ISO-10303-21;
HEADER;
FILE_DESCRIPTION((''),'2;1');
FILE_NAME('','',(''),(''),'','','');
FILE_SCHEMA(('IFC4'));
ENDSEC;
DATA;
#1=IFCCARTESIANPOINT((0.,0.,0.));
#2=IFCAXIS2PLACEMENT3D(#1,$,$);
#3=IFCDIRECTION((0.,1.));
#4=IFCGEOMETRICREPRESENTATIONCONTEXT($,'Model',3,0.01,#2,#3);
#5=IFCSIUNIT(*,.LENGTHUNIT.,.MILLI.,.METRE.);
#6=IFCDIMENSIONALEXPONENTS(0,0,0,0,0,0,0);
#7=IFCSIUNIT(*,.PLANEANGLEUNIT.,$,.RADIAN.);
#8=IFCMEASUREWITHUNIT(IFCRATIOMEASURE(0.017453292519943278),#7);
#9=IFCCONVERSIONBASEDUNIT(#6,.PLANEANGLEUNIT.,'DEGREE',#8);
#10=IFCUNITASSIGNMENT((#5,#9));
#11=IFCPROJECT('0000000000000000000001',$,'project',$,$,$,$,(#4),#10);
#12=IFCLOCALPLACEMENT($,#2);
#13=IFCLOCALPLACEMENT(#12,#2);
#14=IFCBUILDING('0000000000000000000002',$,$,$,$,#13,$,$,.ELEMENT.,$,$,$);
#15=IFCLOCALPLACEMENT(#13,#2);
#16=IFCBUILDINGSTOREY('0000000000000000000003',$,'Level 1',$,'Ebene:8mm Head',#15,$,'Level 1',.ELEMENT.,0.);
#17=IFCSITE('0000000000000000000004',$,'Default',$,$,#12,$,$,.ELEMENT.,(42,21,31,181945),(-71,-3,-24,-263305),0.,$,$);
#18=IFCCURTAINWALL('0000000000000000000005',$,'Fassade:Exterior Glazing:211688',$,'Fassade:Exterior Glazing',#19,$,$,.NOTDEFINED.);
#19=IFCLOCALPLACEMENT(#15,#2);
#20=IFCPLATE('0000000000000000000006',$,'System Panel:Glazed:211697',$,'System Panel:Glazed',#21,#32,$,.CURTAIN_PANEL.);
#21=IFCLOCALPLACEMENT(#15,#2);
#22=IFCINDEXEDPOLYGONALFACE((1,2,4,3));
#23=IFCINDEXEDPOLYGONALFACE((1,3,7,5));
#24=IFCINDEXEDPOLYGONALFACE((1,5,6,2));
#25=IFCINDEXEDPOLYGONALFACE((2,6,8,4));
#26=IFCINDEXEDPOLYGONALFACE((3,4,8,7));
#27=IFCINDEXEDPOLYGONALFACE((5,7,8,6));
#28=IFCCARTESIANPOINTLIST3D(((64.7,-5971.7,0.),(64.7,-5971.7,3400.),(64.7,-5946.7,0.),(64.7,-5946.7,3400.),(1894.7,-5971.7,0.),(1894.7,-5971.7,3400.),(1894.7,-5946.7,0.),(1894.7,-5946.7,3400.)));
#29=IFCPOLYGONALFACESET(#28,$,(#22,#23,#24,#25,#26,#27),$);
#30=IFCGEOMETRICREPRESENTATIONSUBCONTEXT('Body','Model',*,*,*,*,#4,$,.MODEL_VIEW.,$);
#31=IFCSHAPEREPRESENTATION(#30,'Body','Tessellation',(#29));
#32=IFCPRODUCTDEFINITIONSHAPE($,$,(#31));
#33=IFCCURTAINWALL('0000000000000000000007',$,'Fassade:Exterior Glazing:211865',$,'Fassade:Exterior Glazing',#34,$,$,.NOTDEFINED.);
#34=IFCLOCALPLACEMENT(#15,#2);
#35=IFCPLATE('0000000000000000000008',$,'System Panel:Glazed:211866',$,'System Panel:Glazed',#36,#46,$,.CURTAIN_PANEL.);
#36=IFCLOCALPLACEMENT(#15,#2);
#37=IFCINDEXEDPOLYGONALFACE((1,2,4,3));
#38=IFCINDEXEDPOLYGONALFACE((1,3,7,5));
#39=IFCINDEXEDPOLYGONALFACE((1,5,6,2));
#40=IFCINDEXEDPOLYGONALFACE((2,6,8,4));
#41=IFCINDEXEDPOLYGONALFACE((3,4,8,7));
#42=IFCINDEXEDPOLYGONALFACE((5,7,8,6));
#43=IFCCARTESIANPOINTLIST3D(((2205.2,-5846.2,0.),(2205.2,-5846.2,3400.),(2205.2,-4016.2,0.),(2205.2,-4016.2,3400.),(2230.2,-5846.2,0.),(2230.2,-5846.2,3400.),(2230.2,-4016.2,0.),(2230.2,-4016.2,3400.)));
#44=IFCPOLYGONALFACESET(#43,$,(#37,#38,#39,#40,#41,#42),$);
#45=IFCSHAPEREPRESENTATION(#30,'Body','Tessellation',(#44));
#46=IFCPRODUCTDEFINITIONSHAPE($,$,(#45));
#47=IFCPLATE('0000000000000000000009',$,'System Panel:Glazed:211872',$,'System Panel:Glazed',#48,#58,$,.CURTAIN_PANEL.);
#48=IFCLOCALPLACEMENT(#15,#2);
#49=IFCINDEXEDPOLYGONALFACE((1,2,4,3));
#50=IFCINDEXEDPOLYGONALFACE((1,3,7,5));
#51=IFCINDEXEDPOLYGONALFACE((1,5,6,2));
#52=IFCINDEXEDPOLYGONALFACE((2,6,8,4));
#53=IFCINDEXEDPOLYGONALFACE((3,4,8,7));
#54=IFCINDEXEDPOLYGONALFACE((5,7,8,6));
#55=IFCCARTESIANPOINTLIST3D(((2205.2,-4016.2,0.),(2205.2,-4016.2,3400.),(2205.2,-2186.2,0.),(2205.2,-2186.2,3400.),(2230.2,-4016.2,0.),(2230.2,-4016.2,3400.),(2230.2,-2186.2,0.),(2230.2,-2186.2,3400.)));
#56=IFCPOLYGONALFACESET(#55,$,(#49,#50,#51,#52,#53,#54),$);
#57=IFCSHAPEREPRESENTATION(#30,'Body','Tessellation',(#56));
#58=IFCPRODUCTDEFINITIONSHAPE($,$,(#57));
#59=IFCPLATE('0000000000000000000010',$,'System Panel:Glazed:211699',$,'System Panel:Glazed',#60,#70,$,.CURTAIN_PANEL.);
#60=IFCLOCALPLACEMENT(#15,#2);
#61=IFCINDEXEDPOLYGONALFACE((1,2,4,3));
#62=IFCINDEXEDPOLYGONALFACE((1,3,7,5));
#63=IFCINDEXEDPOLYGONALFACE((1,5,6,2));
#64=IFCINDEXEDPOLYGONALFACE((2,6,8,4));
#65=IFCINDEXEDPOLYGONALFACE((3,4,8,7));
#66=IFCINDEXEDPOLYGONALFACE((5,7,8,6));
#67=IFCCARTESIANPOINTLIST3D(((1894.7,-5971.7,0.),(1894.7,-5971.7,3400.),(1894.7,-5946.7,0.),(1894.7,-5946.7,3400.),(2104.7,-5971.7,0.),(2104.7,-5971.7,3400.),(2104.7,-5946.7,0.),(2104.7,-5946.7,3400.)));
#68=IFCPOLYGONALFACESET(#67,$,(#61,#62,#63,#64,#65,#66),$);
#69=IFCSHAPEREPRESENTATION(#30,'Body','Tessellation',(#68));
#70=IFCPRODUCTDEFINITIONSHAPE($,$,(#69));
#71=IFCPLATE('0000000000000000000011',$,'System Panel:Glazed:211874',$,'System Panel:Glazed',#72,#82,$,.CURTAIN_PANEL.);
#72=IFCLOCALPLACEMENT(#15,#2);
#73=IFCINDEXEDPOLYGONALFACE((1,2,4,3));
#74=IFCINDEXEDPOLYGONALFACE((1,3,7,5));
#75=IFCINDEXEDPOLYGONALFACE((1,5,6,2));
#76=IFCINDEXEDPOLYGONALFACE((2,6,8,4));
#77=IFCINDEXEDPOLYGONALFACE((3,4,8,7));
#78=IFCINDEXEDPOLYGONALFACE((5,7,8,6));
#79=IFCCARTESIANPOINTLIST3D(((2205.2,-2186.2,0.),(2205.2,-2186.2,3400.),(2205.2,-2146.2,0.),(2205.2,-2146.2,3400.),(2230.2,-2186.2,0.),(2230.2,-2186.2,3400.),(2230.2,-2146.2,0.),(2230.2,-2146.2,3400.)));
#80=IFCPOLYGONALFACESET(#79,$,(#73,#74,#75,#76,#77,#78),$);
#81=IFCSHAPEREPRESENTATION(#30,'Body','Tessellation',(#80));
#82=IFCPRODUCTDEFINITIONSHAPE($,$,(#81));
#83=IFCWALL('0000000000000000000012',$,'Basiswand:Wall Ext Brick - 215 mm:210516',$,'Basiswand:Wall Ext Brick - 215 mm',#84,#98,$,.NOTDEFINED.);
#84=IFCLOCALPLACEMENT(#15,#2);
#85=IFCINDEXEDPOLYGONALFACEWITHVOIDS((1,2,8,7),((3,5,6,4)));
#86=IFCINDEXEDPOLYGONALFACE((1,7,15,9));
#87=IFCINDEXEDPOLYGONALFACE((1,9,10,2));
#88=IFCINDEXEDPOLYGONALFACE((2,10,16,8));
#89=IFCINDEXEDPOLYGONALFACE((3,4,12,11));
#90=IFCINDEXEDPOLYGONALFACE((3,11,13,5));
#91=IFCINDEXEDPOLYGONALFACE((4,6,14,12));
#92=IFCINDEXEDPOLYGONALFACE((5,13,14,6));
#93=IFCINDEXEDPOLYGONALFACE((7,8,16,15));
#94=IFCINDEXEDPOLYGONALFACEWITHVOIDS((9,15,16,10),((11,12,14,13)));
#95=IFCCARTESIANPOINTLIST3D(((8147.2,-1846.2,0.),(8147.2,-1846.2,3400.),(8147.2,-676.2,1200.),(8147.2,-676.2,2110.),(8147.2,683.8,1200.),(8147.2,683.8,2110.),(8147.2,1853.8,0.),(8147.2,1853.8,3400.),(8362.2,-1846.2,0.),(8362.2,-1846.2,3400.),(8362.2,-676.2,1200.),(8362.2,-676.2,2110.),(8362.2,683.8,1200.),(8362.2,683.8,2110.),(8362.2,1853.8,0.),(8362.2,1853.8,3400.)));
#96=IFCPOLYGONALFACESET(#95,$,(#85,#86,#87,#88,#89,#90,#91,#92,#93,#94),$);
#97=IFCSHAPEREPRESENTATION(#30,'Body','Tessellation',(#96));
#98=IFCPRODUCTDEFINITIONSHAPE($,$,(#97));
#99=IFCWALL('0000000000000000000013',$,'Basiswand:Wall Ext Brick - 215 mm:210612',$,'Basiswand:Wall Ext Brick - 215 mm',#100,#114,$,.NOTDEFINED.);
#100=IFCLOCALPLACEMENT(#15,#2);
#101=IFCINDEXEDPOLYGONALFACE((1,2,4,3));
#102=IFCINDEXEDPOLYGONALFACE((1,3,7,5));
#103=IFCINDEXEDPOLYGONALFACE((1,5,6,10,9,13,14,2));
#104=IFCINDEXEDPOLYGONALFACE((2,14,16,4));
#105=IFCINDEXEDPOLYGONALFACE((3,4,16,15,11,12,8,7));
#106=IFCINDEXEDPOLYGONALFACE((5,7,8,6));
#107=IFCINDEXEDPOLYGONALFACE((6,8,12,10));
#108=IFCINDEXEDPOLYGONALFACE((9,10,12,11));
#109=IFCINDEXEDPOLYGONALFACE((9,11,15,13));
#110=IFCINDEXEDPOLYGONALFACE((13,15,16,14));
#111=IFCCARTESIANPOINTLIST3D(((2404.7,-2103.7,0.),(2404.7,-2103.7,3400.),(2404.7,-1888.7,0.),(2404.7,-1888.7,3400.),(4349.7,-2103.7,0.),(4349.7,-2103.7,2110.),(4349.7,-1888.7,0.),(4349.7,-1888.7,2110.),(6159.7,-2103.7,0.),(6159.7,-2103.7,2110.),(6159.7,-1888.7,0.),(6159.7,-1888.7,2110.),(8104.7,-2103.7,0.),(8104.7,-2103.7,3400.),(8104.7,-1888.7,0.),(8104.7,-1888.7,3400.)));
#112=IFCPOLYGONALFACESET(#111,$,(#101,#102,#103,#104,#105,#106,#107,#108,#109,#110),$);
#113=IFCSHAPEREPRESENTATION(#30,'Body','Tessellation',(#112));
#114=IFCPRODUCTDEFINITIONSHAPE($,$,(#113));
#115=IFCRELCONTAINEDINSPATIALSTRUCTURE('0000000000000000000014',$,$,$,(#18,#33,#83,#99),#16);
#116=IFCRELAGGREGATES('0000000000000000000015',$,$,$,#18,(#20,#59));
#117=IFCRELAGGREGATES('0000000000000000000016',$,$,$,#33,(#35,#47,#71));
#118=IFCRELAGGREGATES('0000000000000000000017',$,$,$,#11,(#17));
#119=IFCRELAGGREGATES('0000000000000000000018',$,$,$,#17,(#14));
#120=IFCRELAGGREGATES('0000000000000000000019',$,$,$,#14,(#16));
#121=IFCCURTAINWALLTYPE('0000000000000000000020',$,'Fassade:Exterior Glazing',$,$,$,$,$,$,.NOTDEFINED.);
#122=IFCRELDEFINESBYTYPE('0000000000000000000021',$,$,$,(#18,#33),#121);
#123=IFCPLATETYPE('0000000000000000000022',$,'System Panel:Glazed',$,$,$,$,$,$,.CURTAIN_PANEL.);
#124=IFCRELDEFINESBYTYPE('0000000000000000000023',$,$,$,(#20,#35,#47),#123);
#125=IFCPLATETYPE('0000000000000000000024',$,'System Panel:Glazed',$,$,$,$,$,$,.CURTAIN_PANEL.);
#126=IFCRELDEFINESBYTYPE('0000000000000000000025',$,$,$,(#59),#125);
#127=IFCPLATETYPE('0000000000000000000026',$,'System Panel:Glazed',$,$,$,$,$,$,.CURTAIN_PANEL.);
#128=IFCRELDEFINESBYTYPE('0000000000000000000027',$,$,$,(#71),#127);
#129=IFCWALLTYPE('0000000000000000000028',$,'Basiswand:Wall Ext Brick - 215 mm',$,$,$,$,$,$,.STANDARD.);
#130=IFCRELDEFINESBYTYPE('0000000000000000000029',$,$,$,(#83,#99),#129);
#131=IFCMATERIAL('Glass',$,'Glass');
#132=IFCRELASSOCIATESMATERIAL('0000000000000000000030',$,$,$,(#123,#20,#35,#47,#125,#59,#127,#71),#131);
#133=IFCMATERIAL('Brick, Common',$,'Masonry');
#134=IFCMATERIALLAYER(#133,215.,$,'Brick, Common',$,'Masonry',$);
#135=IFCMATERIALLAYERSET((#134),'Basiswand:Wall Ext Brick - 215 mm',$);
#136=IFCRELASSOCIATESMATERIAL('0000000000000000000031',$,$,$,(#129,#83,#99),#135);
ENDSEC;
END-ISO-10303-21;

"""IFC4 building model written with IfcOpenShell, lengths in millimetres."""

from ifc_helpers import new_model, entity, si_unit, converted_unit, direction, frame, frame_2d, origin, origin_2d_with_axis, place, context, subcontext, project, spatial, rectangle, extrude, source, transform, mapped, material, layer, layer_set, layer_usage, type_object, type_shapes, element, aggregate, save


model = new_model("IFC4")

# Units and contexts
model_context = context("Model", 3, precision=0.01, world=origin(), true_north=direction((0.0, 1.0)))
body_context = subcontext(model_context, "Body", "Model", "MODEL_VIEW")
ifc_project = project(units=[si_unit("LENGTHUNIT", "METRE", prefix="MILLI"), converted_unit("PLANEANGLEUNIT", "DEGREE", entity("IfcRatioMeasure", 0.017453292519943278), si_unit("PLANEANGLEUNIT", "RADIAN"), dimensions=[0, 0, 0, 0, 0, 0, 0])], contexts=[model_context])

# Site, building, storey
site_placement = place(None, origin())
site = spatial("IfcSite", under=ifc_project, at=site_placement, Name="Default", CompositionType="ELEMENT", RefLatitude=(42, 21, 31, 181945), RefLongitude=(-71, -3, -24, -263305), RefElevation=0.0)
building_placement = place(site_placement, origin())
building = spatial("IfcBuilding", under=site, at=building_placement, CompositionType="ELEMENT")
storey_placement = place(building_placement, origin())
storey = spatial("IfcBuildingStorey", under=building, at=storey_placement, Name="Level 1", ObjectType="Ebene:8mm Head", LongName="Level 1", CompositionType="ELEMENT", Elevation=0.0)

# Curtain wall, plate
curtain_wall_type = type_object("IfcCurtainWallType", Name="Fassade:Exterior Glazing", PredefinedType="NOTDEFINED")
curtain_wall_1_placement = place(storey_placement, origin())
curtain_wall_1 = element("IfcCurtainWall", 1, at=curtain_wall_1_placement, inside=storey, type_object=curtain_wall_type, Name="Fassade:Exterior Glazing:211688", ObjectType="Fassade:Exterior Glazing", PredefinedType="NOTDEFINED")
ifc_material_1 = material(Name="Glass", Category="Glass")
plate_type_1 = type_object("IfcPlateType", Name="System Panel:Glazed", PredefinedType="CURTAIN_PANEL", material=ifc_material_1)
shared_shape_1 = source(origin(), body_context, "Body", "SweptSolid", [
    extrude(rectangle(XDim=25.0, YDim=1830.0, at=origin_2d_with_axis()), frame((915.0, 12.5, 0.0), z_axis=(0.0, 0.0, 1.0), x_axis=(0.0, 1.0, 0.0)), (0.0, 0.0, 1.0), 3400.0),
])
type_shapes(plate_type_1, [shared_shape_1])
plate_1_placement = place(curtain_wall_1_placement, frame((64.7, -5971.7, 0.0)))
plate_1 = element("IfcPlate", 2, at=plate_1_placement, type_object=plate_type_1, material=ifc_material_1, Name="System Panel:Glazed:211697", ObjectType="System Panel:Glazed", PredefinedType="CURTAIN_PANEL", context=body_context, shape_type="MappedRepresentation", body=[
    mapped(shared_shape_1, transform((0.0, 0.0, 0.0), scale=1.0)),
])

# Curtain wall, plates
curtain_wall_2_placement = place(storey_placement, origin())
curtain_wall_2 = element("IfcCurtainWall", 3, at=curtain_wall_2_placement, inside=storey, type_object=curtain_wall_type, Name="Fassade:Exterior Glazing:211865", ObjectType="Fassade:Exterior Glazing", PredefinedType="NOTDEFINED")
plate_2_placement = place(curtain_wall_2_placement, frame((2230.2, -5846.2, 0.0), z_axis=(0.0, 0.0, 1.0), x_axis=(0.0, 1.0, 0.0)))
plate_2 = element("IfcPlate", 4, at=plate_2_placement, type_object=plate_type_1, material=ifc_material_1, Name="System Panel:Glazed:211866", ObjectType="System Panel:Glazed", PredefinedType="CURTAIN_PANEL", context=body_context, shape_type="MappedRepresentation", body=[
    mapped(shared_shape_1, transform((0.0, 0.0, 0.0), scale=1.0)),
])
plate_3_placement = place(curtain_wall_2_placement, frame((2230.2, -4016.2, 0.0), z_axis=(0.0, 0.0, 1.0), x_axis=(0.0, 1.0, 0.0)))
plate_3 = element("IfcPlate", 5, at=plate_3_placement, type_object=plate_type_1, material=ifc_material_1, Name="System Panel:Glazed:211872", ObjectType="System Panel:Glazed", PredefinedType="CURTAIN_PANEL", context=body_context, shape_type="MappedRepresentation", body=[
    mapped(shared_shape_1, transform((0.0, 0.0, 0.0), scale=1.0)),
])

# Plates
plate_type_2 = type_object("IfcPlateType", Name="System Panel:Glazed", PredefinedType="CURTAIN_PANEL", material=ifc_material_1)
shared_shape_2 = source(origin(), body_context, "Body", "SweptSolid", [
    extrude(rectangle(XDim=25.0, YDim=210.0, at=origin_2d_with_axis()), frame((105.0, 12.5, 0.0), z_axis=(0.0, 0.0, 1.0), x_axis=(0.0, 1.0, 0.0)), (0.0, 0.0, 1.0), 3400.0),
])
type_shapes(plate_type_2, [shared_shape_2])
plate_4_placement = place(curtain_wall_1_placement, frame((1894.7, -5971.7, 0.0)))
plate_4 = element("IfcPlate", 6, at=plate_4_placement, type_object=plate_type_2, material=ifc_material_1, Name="System Panel:Glazed:211699", ObjectType="System Panel:Glazed", PredefinedType="CURTAIN_PANEL", context=body_context, shape_type="MappedRepresentation", body=[
    mapped(shared_shape_2, transform((0.0, 0.0, 0.0), scale=1.0)),
])
aggregate(curtain_wall_1, [plate_1, plate_4])
plate_type_3 = type_object("IfcPlateType", Name="System Panel:Glazed", PredefinedType="CURTAIN_PANEL", material=ifc_material_1)
shared_shape_3 = source(origin(), body_context, "Body", "SweptSolid", [
    extrude(rectangle(XDim=25.0, YDim=40.0, at=origin_2d_with_axis()), frame((20.0, 12.5, 0.0), z_axis=(0.0, 0.0, 1.0), x_axis=(0.0, 1.0, 0.0)), (0.0, 0.0, 1.0), 3400.0),
])
type_shapes(plate_type_3, [shared_shape_3])
plate_5_placement = place(curtain_wall_2_placement, frame((2230.2, -2186.2, 0.0), z_axis=(0.0, 0.0, 1.0), x_axis=(0.0, 1.0, 0.0)))
plate_5 = element("IfcPlate", 7, at=plate_5_placement, type_object=plate_type_3, material=ifc_material_1, Name="System Panel:Glazed:211874", ObjectType="System Panel:Glazed", PredefinedType="CURTAIN_PANEL", context=body_context, shape_type="MappedRepresentation", body=[
    mapped(shared_shape_3, transform((0.0, 0.0, 0.0), scale=1.0)),
])
aggregate(curtain_wall_2, [plate_2, plate_3, plate_5])

# Walls, openings
ifc_material_2 = material(Name="Brick, Common", Category="Masonry")
ifc_layer = layer(ifc_material_2, 215.0, Name="Brick, Common", Category="Masonry")
ifc_layer_set = layer_set([ifc_layer], Name="Basiswand:Wall Ext Brick - 215 mm")
ifc_layer_usage_1 = layer_usage(ifc_layer_set, "AXIS2", "NEGATIVE", 107.5)
wall_type = type_object("IfcWallType", Name="Basiswand:Wall Ext Brick - 215 mm", PredefinedType="STANDARD", material=ifc_layer_set)
wall_1_placement = place(storey_placement, frame((8254.7, -1846.2, 0.0), z_axis=(0.0, 0.0, 1.0), x_axis=(0.0, 1.0, 0.0)))
wall_1 = element("IfcWall", 8, at=wall_1_placement, inside=storey, type_object=wall_type, material=ifc_layer_usage_1, Name="Basiswand:Wall Ext Brick - 215 mm:210516", ObjectType="Basiswand:Wall Ext Brick - 215 mm", PredefinedType="NOTDEFINED", context=body_context, shape_type="SweptSolid", body=[
    extrude(rectangle(XDim=3700.0, YDim=215.0, at=frame_2d((1850.0, 0.0), x_axis=(-1.0, 0.0))), origin(), (0.0, 0.0, 1.0), 3400.0),
])
opening_1_placement = place(wall_1_placement, frame((2530.0, 107.5, 1200.0)))
element("IfcOpeningElement", 9, at=opening_1_placement, cuts=wall_1, PredefinedType="OPENING", context=body_context, shape_type="SweptSolid", body=[
    extrude(rectangle(XDim=910.0, YDim=1360.0, at=frame_2d((455.0, 680.0), x_axis=(-1.0, 0.0))), frame((0.0, 0.0, 0.0), z_axis=(0.0, -1.0, 0.0), x_axis=(0.0, 0.0, 1.0)), (0.0, 0.0, 1.0), 215.0),
])
ifc_layer_usage_2 = layer_usage(ifc_layer_set, "AXIS2", "NEGATIVE", 107.5)
wall_2_placement = place(storey_placement, frame((2404.7, -1996.2, 0.0)))
wall_2 = element("IfcWall", 10, at=wall_2_placement, inside=storey, type_object=wall_type, material=ifc_layer_usage_2, Name="Basiswand:Wall Ext Brick - 215 mm:210612", ObjectType="Basiswand:Wall Ext Brick - 215 mm", PredefinedType="NOTDEFINED", context=body_context, shape_type="SweptSolid", body=[
    extrude(rectangle(XDim=5700.0, YDim=215.0, at=frame_2d((2850.0, 0.0), x_axis=(1.0, 0.0))), origin(), (0.0, 0.0, 1.0), 3400.0),
])
opening_2_placement = place(wall_2_placement, frame((3755.0, 107.5, 0.0)))
element("IfcOpeningElement", 11, at=opening_2_placement, cuts=wall_2, PredefinedType="OPENING", context=body_context, shape_type="SweptSolid", body=[
    extrude(rectangle(XDim=2110.0, YDim=1810.0, at=frame_2d((1055.0, 905.0), x_axis=(-1.0, 0.0))), frame((0.0, 0.0, 0.0), z_axis=(0.0, -1.0, 0.0), x_axis=(0.0, 0.0, 1.0)), (0.0, 0.0, 1.0), 215.0),
])

save(model, "model.ifc")
